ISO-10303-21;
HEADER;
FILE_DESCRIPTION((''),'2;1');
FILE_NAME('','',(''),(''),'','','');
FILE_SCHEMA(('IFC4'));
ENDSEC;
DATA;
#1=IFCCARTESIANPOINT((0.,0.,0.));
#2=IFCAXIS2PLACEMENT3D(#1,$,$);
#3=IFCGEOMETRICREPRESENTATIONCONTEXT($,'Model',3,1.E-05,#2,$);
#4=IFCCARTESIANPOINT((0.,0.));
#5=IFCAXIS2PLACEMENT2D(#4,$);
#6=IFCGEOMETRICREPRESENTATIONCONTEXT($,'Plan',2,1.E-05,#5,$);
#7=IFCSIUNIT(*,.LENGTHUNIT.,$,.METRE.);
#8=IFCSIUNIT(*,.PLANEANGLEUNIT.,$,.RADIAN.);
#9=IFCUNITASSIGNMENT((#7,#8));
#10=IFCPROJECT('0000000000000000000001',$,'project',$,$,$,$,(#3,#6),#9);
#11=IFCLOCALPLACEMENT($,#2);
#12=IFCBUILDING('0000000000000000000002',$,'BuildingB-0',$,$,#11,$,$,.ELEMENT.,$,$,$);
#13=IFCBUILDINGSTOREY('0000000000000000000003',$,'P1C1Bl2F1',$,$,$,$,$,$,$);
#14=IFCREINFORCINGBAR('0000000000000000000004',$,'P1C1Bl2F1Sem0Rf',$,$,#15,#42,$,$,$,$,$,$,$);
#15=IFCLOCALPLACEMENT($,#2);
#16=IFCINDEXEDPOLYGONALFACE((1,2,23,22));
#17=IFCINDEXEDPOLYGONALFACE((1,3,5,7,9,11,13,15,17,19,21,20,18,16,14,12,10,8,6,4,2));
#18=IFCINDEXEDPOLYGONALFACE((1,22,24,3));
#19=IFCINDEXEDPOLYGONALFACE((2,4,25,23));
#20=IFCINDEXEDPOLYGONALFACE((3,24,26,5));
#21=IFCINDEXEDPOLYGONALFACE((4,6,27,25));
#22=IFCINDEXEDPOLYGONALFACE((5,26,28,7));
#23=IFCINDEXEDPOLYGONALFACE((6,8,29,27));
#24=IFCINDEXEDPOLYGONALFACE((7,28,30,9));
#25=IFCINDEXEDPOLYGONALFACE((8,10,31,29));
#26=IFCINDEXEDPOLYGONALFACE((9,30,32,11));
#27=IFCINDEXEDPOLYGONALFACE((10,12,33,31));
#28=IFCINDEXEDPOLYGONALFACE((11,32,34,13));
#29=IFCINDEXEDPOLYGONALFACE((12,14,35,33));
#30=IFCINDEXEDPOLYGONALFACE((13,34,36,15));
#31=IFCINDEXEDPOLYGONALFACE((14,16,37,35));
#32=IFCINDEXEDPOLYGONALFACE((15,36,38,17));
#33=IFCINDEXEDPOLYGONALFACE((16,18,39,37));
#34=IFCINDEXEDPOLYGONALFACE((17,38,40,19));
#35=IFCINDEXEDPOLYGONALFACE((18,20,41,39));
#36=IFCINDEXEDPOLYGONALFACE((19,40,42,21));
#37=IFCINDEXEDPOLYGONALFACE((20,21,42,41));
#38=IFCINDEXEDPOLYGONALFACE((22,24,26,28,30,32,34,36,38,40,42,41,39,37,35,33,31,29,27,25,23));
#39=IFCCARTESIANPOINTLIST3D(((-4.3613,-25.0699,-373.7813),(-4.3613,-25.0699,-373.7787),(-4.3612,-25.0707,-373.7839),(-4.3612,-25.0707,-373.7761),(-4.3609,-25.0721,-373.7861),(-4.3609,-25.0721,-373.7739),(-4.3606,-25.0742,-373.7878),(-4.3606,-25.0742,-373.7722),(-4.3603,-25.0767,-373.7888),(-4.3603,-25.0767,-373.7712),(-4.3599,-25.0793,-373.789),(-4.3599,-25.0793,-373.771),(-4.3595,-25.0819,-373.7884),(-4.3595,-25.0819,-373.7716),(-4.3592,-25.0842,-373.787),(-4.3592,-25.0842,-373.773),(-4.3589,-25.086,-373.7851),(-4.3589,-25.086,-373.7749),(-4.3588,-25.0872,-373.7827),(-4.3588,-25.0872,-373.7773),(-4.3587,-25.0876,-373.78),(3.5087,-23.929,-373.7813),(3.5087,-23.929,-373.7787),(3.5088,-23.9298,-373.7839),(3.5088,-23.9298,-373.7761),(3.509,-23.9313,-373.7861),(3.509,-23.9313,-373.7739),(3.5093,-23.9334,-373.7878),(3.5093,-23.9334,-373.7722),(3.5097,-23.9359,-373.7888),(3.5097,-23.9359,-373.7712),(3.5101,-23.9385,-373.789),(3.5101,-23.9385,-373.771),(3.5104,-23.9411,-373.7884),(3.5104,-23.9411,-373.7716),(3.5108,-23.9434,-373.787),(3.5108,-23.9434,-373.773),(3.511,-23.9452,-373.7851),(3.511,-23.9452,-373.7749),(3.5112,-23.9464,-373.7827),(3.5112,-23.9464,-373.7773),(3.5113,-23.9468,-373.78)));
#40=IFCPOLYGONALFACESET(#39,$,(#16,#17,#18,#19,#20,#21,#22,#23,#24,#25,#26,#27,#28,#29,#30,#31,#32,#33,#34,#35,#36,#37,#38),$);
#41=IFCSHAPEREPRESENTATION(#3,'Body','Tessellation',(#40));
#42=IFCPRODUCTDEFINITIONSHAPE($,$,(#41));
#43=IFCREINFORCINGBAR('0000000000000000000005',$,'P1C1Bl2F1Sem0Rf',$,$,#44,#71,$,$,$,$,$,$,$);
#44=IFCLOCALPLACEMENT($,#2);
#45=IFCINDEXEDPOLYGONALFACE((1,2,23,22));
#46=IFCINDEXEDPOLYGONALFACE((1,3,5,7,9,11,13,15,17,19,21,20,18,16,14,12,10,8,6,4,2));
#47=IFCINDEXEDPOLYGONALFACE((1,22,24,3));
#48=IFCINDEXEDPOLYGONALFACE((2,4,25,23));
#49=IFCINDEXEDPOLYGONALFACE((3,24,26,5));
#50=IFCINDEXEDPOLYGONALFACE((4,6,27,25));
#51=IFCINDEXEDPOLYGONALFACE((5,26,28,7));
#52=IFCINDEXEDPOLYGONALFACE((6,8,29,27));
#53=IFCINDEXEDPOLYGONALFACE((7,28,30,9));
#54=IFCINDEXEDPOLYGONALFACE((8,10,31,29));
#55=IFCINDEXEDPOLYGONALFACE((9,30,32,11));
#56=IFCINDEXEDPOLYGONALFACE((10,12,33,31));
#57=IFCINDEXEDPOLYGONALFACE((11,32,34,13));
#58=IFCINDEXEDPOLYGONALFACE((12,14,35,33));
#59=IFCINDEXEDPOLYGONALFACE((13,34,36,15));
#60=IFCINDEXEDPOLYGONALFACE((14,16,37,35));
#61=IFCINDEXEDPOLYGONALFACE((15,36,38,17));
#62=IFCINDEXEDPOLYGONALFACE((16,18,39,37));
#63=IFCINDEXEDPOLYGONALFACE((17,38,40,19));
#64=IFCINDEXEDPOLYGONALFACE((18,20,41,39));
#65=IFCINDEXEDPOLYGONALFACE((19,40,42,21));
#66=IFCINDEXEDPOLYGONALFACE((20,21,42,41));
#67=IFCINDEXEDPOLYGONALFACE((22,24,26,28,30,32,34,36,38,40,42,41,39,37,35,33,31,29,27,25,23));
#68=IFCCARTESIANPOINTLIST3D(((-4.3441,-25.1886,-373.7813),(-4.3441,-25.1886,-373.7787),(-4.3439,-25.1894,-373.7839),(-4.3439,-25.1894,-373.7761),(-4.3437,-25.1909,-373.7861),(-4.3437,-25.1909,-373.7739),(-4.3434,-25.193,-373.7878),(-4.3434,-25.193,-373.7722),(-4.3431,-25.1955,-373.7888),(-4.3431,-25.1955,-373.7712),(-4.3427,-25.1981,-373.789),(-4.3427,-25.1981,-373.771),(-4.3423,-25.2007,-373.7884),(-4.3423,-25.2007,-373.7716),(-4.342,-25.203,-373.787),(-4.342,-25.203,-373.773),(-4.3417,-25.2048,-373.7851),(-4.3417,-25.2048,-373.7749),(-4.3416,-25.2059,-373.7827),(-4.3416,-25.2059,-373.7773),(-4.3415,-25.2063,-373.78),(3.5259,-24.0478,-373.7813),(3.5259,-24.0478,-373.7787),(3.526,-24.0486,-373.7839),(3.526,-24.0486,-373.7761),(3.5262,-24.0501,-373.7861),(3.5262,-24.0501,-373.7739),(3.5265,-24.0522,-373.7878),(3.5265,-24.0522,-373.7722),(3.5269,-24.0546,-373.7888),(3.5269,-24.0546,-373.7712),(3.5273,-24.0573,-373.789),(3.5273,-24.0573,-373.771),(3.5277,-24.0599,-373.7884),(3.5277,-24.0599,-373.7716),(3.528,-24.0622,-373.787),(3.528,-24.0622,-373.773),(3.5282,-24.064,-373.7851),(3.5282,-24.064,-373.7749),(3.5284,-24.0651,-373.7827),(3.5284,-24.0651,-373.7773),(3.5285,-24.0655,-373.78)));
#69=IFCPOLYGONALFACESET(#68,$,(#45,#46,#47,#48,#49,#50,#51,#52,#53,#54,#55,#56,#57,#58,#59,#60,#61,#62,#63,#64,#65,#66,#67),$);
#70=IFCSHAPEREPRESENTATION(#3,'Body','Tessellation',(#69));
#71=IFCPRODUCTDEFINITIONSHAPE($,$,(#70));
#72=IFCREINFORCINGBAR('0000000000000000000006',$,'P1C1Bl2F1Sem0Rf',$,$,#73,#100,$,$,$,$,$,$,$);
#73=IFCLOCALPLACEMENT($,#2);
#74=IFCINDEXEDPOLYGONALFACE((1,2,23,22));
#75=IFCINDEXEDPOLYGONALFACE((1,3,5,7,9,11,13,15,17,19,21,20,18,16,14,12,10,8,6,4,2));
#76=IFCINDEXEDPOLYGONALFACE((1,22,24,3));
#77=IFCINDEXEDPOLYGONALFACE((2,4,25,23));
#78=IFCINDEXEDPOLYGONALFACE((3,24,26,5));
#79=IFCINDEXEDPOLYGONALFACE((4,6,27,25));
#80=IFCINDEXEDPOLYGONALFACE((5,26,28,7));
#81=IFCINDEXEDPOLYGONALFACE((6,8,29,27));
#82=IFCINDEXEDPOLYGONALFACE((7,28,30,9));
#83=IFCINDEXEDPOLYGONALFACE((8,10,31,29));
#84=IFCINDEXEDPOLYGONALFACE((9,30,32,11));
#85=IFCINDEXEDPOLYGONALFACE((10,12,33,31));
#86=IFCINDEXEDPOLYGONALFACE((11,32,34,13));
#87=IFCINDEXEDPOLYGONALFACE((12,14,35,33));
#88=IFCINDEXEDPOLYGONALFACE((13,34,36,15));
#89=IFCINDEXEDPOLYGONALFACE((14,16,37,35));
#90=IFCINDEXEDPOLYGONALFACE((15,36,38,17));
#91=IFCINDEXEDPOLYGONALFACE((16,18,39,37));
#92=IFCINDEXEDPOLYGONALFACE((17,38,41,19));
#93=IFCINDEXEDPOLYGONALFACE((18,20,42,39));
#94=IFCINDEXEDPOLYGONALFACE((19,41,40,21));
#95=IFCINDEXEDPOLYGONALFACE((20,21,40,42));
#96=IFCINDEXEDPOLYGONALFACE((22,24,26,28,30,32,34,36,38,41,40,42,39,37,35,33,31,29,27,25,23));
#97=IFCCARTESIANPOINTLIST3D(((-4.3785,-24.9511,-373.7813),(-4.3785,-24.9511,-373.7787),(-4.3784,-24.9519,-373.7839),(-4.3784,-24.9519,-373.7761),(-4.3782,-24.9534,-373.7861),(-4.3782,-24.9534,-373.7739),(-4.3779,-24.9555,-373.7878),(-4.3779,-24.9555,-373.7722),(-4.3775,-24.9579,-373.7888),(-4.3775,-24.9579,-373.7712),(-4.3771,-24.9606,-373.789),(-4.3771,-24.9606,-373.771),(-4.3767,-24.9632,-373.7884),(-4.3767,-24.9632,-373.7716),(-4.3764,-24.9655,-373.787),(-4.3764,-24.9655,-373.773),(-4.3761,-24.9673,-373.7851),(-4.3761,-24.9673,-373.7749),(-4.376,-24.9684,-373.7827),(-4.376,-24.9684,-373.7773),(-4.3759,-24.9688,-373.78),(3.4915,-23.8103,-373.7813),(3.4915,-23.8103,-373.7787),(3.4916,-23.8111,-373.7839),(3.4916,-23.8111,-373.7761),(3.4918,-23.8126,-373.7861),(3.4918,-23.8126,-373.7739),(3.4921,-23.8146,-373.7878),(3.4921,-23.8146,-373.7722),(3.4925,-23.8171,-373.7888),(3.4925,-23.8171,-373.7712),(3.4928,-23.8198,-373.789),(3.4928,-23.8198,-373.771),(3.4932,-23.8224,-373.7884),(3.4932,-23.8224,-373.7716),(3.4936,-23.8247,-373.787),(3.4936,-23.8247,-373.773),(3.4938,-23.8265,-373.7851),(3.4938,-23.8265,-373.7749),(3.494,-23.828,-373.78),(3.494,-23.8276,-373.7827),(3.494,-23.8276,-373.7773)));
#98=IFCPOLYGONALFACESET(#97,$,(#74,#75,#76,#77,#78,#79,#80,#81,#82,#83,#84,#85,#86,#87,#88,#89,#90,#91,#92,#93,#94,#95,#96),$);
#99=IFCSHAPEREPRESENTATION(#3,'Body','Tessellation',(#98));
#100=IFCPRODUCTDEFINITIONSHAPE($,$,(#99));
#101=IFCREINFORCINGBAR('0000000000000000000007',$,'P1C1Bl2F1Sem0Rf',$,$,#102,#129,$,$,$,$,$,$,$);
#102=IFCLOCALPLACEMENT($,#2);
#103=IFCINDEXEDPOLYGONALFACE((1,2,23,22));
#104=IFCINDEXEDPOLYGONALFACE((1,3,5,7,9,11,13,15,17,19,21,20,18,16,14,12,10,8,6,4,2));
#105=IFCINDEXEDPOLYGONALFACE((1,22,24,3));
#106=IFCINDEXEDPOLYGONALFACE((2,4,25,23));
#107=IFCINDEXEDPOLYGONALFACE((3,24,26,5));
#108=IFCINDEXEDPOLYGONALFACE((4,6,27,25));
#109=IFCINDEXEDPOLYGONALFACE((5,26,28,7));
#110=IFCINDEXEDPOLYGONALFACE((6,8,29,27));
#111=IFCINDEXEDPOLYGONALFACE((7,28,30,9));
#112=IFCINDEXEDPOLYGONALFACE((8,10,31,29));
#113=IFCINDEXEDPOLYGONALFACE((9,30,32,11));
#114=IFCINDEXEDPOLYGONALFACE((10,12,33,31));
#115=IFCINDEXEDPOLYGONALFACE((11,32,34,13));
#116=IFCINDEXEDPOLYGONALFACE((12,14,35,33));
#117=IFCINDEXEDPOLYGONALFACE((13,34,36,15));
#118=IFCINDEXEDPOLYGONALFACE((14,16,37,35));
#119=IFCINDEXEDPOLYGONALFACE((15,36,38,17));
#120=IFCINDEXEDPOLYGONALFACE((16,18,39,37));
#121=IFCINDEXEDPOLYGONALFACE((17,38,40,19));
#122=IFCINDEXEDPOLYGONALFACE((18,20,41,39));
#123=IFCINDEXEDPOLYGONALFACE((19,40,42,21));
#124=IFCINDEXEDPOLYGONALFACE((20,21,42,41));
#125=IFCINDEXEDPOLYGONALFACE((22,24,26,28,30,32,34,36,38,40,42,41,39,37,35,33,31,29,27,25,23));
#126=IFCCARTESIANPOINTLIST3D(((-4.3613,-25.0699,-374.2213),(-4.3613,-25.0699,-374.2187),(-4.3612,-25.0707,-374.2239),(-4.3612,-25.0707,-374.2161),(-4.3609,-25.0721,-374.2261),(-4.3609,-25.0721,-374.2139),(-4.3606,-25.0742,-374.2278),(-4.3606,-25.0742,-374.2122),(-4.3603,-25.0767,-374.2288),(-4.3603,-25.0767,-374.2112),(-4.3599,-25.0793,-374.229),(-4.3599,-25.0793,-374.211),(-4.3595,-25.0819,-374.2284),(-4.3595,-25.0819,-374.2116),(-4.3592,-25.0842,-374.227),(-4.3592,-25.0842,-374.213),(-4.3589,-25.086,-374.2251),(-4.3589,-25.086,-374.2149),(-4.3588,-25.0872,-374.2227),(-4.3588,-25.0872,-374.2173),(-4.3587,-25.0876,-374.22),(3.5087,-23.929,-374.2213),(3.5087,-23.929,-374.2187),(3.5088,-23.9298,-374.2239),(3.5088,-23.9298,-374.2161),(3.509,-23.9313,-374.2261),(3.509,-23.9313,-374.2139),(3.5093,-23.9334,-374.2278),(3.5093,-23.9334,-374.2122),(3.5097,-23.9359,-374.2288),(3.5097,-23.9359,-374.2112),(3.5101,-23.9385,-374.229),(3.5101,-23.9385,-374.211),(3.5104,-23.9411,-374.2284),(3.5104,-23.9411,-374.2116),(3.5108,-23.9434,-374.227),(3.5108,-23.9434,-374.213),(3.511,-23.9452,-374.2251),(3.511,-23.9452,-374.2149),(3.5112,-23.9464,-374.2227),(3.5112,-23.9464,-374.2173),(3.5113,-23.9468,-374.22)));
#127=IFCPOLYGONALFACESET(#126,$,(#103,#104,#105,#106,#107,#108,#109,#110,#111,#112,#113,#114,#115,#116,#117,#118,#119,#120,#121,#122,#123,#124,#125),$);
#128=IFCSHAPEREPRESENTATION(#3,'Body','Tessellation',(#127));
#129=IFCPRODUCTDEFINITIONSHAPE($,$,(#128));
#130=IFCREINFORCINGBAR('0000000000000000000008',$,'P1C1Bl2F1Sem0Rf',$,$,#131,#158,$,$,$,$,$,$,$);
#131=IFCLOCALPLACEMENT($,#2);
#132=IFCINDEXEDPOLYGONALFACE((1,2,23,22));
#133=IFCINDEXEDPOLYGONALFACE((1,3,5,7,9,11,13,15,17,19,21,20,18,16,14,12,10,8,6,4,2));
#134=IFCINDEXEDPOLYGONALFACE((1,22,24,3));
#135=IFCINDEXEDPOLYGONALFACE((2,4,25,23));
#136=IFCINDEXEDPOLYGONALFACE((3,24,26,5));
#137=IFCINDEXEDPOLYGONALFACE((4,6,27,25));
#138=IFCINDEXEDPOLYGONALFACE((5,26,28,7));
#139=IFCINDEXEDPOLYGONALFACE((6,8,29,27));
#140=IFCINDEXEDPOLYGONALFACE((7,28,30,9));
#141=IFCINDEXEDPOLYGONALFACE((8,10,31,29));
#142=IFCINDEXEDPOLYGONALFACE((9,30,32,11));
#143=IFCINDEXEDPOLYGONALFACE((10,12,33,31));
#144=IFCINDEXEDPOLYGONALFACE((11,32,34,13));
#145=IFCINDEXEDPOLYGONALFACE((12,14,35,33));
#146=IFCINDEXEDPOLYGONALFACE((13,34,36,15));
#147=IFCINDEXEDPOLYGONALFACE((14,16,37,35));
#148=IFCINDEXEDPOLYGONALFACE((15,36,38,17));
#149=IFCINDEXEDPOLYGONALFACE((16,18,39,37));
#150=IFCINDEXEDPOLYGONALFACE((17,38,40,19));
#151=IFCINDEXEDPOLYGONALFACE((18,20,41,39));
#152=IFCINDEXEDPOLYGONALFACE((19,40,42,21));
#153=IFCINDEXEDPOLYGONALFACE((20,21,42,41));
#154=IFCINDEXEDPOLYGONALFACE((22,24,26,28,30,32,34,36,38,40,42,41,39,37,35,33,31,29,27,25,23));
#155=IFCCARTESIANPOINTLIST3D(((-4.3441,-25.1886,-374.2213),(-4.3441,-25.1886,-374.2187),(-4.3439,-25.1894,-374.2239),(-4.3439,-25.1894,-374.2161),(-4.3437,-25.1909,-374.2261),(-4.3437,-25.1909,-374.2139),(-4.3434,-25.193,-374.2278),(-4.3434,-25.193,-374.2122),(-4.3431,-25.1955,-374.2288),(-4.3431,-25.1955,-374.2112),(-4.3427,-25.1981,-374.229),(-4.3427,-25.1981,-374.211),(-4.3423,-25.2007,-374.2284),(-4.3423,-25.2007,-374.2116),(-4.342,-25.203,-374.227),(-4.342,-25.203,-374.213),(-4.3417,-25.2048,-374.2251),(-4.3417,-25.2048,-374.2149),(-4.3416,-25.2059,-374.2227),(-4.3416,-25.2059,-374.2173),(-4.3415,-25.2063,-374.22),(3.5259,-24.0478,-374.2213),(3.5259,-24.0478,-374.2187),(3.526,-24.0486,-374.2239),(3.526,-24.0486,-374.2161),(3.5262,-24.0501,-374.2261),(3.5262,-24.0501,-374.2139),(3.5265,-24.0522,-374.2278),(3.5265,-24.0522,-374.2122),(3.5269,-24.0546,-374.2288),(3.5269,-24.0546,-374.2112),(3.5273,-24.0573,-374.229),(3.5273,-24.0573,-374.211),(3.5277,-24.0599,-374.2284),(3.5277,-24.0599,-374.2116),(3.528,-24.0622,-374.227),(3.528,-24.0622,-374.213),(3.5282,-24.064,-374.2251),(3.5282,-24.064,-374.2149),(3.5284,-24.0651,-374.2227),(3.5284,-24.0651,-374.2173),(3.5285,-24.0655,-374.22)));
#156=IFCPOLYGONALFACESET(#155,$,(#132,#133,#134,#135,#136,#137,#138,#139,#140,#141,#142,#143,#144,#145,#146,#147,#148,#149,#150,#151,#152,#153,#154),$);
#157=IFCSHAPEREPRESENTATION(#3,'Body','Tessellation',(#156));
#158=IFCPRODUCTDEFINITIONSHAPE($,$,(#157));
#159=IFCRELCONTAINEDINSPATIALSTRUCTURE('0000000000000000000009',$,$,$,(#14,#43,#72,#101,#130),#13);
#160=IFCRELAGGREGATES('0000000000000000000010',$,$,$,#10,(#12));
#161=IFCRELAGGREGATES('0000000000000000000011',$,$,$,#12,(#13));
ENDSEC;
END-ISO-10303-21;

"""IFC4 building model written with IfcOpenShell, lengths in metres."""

from ifc_helpers import new_model, entity, si_unit, origin, origin_2d, place, context, project, spatial, element, save


model = new_model("IFC4")

# Units and contexts
model_context = context("Model", 3, precision=1e-05, world=origin())
plan_context = context("Plan", 2, precision=1e-05, world=origin_2d())
ifc_project = project(units=[si_unit("LENGTHUNIT", "METRE"), si_unit("PLANEANGLEUNIT", "RADIAN")], contexts=[model_context, plan_context])

# Building, storey
building_placement = place(None, origin())
building = spatial("IfcBuilding", under=ifc_project, at=building_placement, Name="BuildingB-0", CompositionType="ELEMENT")
storey = spatial("IfcBuildingStorey", under=building, Name="P1C1Bl2F1")

# Reinforcing bars
element("IfcReinforcingBar", 1, inside=storey, Name="P1C1Bl2F1Sem0Rf", context=model_context, shape_type="SweptSolid", body=[
    entity("IfcSurfaceCurveSweptAreaSolid", entity("IfcCircleProfileDef", "AREA", None, None, 0.009), None, entity("IfcPolyline", [entity("IfcCartesianPoint", [4.36, 25.0787, 373.78]), entity("IfcCartesianPoint", [-3.51, 23.9379, 373.78])]), None, None, entity("IfcPlane", entity("IfcAxis2Placement3D", entity("IfcCartesianPoint", [4.36, 25.0787, 373.78]), entity("IfcDirection", [0.0, 0.0, 1.0]), entity("IfcDirection", [1.0, 0.0, 0.0])))),
])
element("IfcReinforcingBar", 2, inside=storey, Name="P1C1Bl2F1Sem0Rf", context=model_context, shape_type="SweptSolid", body=[
    entity("IfcSurfaceCurveSweptAreaSolid", entity("IfcCircleProfileDef", "AREA", None, None, 0.009), None, entity("IfcPolyline", [entity("IfcCartesianPoint", [4.3428, 25.1974, 373.78]), entity("IfcCartesianPoint", [-3.5272, 24.0566, 373.78])]), None, None, entity("IfcPlane", entity("IfcAxis2Placement3D", entity("IfcCartesianPoint", [4.3428, 25.1974, 373.78]), entity("IfcDirection", [0.0, 0.0, 1.0]), entity("IfcDirection", [1.0, 0.0, 0.0])))),
])
element("IfcReinforcingBar", 3, inside=storey, Name="P1C1Bl2F1Sem0Rf", context=model_context, shape_type="SweptSolid", body=[
    entity("IfcSurfaceCurveSweptAreaSolid", entity("IfcCircleProfileDef", "AREA", None, None, 0.009), None, entity("IfcPolyline", [entity("IfcCartesianPoint", [4.3772, 24.9599, 373.78]), entity("IfcCartesianPoint", [-3.4927, 23.8191, 373.78])]), None, None, entity("IfcPlane", entity("IfcAxis2Placement3D", entity("IfcCartesianPoint", [4.3772, 24.9599, 373.78]), entity("IfcDirection", [0.0, 0.0, 1.0]), entity("IfcDirection", [1.0, 0.0, 0.0])))),
])
element("IfcReinforcingBar", 4, inside=storey, Name="P1C1Bl2F1Sem0Rf", context=model_context, shape_type="SweptSolid", body=[
    entity("IfcSurfaceCurveSweptAreaSolid", entity("IfcCircleProfileDef", "AREA", None, None, 0.009), None, entity("IfcPolyline", [entity("IfcCartesianPoint", [4.36, 25.0787, 374.22]), entity("IfcCartesianPoint", [-3.51, 23.9379, 374.22])]), None, None, entity("IfcPlane", entity("IfcAxis2Placement3D", entity("IfcCartesianPoint", [4.36, 25.0787, 374.22]), entity("IfcDirection", [0.0, 0.0, 1.0]), entity("IfcDirection", [1.0, 0.0, 0.0])))),
])
element("IfcReinforcingBar", 5, inside=storey, Name="P1C1Bl2F1Sem0Rf", context=model_context, shape_type="SweptSolid", body=[
    entity("IfcSurfaceCurveSweptAreaSolid", entity("IfcCircleProfileDef", "AREA", None, None, 0.009), None, entity("IfcPolyline", [entity("IfcCartesianPoint", [4.3428, 25.1974, 374.22]), entity("IfcCartesianPoint", [-3.5272, 24.0566, 374.22])]), None, None, entity("IfcPlane", entity("IfcAxis2Placement3D", entity("IfcCartesianPoint", [4.3428, 25.1974, 374.22]), entity("IfcDirection", [0.0, 0.0, 1.0]), entity("IfcDirection", [1.0, 0.0, 0.0])))),
])

save(model, "model.ifc")
